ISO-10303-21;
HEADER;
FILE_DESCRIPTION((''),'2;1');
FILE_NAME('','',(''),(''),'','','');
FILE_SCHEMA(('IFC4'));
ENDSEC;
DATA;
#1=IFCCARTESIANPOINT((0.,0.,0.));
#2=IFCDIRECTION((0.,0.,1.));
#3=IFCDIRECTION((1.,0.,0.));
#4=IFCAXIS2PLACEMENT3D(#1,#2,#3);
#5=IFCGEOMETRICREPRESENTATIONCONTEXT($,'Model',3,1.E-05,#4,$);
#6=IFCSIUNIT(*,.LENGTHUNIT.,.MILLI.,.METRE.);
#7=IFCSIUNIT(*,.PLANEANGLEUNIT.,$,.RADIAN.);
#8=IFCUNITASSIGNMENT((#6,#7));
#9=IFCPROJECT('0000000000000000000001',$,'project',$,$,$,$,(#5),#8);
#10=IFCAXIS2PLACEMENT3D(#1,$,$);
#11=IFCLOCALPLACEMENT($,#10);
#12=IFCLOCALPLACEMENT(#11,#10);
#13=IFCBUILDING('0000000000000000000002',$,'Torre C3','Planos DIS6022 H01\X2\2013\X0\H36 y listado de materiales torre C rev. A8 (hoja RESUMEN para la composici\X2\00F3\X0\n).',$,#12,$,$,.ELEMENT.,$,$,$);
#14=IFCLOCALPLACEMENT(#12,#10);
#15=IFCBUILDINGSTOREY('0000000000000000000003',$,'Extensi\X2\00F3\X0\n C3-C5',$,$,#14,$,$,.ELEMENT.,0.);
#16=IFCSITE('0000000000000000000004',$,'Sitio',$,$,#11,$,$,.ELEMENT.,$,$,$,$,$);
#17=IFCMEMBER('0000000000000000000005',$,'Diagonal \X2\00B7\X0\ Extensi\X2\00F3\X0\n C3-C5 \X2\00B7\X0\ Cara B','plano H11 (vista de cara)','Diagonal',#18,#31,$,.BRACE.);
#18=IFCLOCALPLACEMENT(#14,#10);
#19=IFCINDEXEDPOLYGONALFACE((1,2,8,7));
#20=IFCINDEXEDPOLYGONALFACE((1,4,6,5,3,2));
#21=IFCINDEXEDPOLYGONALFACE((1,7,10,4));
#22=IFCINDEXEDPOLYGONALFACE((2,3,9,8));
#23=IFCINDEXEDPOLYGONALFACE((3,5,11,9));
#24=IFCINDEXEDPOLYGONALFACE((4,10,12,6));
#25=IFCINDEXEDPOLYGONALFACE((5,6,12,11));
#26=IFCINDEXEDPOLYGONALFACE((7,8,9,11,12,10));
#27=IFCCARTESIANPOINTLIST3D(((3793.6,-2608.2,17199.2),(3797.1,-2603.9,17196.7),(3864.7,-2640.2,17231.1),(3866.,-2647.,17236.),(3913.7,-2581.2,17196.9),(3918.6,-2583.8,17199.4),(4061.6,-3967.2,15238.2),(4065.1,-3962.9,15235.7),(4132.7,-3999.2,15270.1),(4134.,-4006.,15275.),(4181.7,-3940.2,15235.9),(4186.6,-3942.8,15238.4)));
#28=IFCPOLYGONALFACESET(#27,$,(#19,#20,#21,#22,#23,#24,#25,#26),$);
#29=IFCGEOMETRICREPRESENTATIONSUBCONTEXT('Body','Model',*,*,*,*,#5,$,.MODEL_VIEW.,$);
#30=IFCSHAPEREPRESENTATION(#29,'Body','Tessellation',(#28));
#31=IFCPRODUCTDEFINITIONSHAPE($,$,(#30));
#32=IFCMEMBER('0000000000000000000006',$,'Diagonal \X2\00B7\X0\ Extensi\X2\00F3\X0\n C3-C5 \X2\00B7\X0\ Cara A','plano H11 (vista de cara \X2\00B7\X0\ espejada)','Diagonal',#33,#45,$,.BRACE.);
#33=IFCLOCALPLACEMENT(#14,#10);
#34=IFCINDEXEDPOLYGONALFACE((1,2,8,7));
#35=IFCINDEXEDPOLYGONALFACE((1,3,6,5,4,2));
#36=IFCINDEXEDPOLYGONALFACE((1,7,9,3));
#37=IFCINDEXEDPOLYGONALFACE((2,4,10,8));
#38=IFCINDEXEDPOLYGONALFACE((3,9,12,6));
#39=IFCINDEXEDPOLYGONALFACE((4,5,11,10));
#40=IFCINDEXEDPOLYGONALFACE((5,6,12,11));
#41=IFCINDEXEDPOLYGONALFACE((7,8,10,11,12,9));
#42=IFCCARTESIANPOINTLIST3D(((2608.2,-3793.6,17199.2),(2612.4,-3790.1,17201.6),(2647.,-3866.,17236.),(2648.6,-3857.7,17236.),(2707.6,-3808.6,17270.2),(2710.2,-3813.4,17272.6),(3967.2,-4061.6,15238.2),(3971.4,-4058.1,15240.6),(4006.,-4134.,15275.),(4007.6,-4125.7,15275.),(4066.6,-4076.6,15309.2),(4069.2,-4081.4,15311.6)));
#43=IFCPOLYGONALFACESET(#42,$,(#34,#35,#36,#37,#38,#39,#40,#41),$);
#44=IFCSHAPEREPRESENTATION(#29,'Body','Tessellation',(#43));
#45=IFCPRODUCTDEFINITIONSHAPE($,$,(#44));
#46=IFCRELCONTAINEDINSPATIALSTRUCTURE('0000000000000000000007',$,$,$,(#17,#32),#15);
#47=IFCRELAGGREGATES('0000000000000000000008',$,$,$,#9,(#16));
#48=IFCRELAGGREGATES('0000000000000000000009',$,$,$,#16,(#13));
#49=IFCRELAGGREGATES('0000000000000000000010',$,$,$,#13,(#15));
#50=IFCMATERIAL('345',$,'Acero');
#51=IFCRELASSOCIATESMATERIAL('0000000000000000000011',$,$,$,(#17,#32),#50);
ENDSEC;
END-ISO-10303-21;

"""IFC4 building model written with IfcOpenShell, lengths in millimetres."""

from ifc_helpers import new_model, si_unit, frame, frame_2d, origin, origin_with_axes, place, context, subcontext, project, spatial, l_section, extrude, material, element, save


model = new_model("IFC4")

# Units and contexts
model_context = context("Model", 3, precision=1e-05, world=origin_with_axes())
body_context = subcontext(model_context, "Body", "Model", "MODEL_VIEW")
ifc_project = project(units=[si_unit("LENGTHUNIT", "METRE", prefix="MILLI"), si_unit("PLANEANGLEUNIT", "RADIAN")], contexts=[model_context])

# Site, building, storey
site_placement = place(None, origin())
site = spatial("IfcSite", under=ifc_project, at=site_placement, Name="Sitio", CompositionType="ELEMENT")
building_placement = place(site_placement, origin())
building = spatial("IfcBuilding", under=site, at=building_placement, Name="Torre C3", Description="Planos DIS6022 H01–H36 y listado de materiales torre C rev. A8 (hoja RESUMEN para la composición).", CompositionType="ELEMENT")
storey_placement = place(building_placement, origin())
storey = spatial("IfcBuildingStorey", under=building, at=storey_placement, Name="Extensión C3-C5", CompositionType="ELEMENT", Elevation=0.0)

# Members
ifc_material_1 = material(Name="345", Category="Acero")
for number, where, z_axis, x_axis, name, description in (
    (1, (3866.0, -2647.0, 17236.0), (0.111626, -0.566042, -0.816784), (-0.803983, 0.431647, -0.409013), "Diagonal · Extensión C3-C5 · Cara B", "plano H11 (vista de cara)"),
    (2, (2647.0, -3866.0, 17236.0), (0.566042, -0.111626, -0.816784), (-0.431647, 0.803983, -0.409013), "Diagonal · Extensión C3-C5 · Cara A", "plano H11 (vista de cara · espejada)"),
):
    element("IfcMember", number, at=place(storey_placement, frame(where, z_axis=z_axis, x_axis=x_axis)), inside=storey, material=ifc_material_1, Name=name, Description=description, ObjectType="Diagonal", PredefinedType="BRACE", context=body_context, shape_type="SweptSolid", body=[
        extrude(l_section(Depth=90.0, Width=90.0, Thickness=6.0, at=frame_2d((45.0, 45.0))), None, (0.0, 0.0, 1.0), 2400.9),
    ])

save(model, "model.ifc")
